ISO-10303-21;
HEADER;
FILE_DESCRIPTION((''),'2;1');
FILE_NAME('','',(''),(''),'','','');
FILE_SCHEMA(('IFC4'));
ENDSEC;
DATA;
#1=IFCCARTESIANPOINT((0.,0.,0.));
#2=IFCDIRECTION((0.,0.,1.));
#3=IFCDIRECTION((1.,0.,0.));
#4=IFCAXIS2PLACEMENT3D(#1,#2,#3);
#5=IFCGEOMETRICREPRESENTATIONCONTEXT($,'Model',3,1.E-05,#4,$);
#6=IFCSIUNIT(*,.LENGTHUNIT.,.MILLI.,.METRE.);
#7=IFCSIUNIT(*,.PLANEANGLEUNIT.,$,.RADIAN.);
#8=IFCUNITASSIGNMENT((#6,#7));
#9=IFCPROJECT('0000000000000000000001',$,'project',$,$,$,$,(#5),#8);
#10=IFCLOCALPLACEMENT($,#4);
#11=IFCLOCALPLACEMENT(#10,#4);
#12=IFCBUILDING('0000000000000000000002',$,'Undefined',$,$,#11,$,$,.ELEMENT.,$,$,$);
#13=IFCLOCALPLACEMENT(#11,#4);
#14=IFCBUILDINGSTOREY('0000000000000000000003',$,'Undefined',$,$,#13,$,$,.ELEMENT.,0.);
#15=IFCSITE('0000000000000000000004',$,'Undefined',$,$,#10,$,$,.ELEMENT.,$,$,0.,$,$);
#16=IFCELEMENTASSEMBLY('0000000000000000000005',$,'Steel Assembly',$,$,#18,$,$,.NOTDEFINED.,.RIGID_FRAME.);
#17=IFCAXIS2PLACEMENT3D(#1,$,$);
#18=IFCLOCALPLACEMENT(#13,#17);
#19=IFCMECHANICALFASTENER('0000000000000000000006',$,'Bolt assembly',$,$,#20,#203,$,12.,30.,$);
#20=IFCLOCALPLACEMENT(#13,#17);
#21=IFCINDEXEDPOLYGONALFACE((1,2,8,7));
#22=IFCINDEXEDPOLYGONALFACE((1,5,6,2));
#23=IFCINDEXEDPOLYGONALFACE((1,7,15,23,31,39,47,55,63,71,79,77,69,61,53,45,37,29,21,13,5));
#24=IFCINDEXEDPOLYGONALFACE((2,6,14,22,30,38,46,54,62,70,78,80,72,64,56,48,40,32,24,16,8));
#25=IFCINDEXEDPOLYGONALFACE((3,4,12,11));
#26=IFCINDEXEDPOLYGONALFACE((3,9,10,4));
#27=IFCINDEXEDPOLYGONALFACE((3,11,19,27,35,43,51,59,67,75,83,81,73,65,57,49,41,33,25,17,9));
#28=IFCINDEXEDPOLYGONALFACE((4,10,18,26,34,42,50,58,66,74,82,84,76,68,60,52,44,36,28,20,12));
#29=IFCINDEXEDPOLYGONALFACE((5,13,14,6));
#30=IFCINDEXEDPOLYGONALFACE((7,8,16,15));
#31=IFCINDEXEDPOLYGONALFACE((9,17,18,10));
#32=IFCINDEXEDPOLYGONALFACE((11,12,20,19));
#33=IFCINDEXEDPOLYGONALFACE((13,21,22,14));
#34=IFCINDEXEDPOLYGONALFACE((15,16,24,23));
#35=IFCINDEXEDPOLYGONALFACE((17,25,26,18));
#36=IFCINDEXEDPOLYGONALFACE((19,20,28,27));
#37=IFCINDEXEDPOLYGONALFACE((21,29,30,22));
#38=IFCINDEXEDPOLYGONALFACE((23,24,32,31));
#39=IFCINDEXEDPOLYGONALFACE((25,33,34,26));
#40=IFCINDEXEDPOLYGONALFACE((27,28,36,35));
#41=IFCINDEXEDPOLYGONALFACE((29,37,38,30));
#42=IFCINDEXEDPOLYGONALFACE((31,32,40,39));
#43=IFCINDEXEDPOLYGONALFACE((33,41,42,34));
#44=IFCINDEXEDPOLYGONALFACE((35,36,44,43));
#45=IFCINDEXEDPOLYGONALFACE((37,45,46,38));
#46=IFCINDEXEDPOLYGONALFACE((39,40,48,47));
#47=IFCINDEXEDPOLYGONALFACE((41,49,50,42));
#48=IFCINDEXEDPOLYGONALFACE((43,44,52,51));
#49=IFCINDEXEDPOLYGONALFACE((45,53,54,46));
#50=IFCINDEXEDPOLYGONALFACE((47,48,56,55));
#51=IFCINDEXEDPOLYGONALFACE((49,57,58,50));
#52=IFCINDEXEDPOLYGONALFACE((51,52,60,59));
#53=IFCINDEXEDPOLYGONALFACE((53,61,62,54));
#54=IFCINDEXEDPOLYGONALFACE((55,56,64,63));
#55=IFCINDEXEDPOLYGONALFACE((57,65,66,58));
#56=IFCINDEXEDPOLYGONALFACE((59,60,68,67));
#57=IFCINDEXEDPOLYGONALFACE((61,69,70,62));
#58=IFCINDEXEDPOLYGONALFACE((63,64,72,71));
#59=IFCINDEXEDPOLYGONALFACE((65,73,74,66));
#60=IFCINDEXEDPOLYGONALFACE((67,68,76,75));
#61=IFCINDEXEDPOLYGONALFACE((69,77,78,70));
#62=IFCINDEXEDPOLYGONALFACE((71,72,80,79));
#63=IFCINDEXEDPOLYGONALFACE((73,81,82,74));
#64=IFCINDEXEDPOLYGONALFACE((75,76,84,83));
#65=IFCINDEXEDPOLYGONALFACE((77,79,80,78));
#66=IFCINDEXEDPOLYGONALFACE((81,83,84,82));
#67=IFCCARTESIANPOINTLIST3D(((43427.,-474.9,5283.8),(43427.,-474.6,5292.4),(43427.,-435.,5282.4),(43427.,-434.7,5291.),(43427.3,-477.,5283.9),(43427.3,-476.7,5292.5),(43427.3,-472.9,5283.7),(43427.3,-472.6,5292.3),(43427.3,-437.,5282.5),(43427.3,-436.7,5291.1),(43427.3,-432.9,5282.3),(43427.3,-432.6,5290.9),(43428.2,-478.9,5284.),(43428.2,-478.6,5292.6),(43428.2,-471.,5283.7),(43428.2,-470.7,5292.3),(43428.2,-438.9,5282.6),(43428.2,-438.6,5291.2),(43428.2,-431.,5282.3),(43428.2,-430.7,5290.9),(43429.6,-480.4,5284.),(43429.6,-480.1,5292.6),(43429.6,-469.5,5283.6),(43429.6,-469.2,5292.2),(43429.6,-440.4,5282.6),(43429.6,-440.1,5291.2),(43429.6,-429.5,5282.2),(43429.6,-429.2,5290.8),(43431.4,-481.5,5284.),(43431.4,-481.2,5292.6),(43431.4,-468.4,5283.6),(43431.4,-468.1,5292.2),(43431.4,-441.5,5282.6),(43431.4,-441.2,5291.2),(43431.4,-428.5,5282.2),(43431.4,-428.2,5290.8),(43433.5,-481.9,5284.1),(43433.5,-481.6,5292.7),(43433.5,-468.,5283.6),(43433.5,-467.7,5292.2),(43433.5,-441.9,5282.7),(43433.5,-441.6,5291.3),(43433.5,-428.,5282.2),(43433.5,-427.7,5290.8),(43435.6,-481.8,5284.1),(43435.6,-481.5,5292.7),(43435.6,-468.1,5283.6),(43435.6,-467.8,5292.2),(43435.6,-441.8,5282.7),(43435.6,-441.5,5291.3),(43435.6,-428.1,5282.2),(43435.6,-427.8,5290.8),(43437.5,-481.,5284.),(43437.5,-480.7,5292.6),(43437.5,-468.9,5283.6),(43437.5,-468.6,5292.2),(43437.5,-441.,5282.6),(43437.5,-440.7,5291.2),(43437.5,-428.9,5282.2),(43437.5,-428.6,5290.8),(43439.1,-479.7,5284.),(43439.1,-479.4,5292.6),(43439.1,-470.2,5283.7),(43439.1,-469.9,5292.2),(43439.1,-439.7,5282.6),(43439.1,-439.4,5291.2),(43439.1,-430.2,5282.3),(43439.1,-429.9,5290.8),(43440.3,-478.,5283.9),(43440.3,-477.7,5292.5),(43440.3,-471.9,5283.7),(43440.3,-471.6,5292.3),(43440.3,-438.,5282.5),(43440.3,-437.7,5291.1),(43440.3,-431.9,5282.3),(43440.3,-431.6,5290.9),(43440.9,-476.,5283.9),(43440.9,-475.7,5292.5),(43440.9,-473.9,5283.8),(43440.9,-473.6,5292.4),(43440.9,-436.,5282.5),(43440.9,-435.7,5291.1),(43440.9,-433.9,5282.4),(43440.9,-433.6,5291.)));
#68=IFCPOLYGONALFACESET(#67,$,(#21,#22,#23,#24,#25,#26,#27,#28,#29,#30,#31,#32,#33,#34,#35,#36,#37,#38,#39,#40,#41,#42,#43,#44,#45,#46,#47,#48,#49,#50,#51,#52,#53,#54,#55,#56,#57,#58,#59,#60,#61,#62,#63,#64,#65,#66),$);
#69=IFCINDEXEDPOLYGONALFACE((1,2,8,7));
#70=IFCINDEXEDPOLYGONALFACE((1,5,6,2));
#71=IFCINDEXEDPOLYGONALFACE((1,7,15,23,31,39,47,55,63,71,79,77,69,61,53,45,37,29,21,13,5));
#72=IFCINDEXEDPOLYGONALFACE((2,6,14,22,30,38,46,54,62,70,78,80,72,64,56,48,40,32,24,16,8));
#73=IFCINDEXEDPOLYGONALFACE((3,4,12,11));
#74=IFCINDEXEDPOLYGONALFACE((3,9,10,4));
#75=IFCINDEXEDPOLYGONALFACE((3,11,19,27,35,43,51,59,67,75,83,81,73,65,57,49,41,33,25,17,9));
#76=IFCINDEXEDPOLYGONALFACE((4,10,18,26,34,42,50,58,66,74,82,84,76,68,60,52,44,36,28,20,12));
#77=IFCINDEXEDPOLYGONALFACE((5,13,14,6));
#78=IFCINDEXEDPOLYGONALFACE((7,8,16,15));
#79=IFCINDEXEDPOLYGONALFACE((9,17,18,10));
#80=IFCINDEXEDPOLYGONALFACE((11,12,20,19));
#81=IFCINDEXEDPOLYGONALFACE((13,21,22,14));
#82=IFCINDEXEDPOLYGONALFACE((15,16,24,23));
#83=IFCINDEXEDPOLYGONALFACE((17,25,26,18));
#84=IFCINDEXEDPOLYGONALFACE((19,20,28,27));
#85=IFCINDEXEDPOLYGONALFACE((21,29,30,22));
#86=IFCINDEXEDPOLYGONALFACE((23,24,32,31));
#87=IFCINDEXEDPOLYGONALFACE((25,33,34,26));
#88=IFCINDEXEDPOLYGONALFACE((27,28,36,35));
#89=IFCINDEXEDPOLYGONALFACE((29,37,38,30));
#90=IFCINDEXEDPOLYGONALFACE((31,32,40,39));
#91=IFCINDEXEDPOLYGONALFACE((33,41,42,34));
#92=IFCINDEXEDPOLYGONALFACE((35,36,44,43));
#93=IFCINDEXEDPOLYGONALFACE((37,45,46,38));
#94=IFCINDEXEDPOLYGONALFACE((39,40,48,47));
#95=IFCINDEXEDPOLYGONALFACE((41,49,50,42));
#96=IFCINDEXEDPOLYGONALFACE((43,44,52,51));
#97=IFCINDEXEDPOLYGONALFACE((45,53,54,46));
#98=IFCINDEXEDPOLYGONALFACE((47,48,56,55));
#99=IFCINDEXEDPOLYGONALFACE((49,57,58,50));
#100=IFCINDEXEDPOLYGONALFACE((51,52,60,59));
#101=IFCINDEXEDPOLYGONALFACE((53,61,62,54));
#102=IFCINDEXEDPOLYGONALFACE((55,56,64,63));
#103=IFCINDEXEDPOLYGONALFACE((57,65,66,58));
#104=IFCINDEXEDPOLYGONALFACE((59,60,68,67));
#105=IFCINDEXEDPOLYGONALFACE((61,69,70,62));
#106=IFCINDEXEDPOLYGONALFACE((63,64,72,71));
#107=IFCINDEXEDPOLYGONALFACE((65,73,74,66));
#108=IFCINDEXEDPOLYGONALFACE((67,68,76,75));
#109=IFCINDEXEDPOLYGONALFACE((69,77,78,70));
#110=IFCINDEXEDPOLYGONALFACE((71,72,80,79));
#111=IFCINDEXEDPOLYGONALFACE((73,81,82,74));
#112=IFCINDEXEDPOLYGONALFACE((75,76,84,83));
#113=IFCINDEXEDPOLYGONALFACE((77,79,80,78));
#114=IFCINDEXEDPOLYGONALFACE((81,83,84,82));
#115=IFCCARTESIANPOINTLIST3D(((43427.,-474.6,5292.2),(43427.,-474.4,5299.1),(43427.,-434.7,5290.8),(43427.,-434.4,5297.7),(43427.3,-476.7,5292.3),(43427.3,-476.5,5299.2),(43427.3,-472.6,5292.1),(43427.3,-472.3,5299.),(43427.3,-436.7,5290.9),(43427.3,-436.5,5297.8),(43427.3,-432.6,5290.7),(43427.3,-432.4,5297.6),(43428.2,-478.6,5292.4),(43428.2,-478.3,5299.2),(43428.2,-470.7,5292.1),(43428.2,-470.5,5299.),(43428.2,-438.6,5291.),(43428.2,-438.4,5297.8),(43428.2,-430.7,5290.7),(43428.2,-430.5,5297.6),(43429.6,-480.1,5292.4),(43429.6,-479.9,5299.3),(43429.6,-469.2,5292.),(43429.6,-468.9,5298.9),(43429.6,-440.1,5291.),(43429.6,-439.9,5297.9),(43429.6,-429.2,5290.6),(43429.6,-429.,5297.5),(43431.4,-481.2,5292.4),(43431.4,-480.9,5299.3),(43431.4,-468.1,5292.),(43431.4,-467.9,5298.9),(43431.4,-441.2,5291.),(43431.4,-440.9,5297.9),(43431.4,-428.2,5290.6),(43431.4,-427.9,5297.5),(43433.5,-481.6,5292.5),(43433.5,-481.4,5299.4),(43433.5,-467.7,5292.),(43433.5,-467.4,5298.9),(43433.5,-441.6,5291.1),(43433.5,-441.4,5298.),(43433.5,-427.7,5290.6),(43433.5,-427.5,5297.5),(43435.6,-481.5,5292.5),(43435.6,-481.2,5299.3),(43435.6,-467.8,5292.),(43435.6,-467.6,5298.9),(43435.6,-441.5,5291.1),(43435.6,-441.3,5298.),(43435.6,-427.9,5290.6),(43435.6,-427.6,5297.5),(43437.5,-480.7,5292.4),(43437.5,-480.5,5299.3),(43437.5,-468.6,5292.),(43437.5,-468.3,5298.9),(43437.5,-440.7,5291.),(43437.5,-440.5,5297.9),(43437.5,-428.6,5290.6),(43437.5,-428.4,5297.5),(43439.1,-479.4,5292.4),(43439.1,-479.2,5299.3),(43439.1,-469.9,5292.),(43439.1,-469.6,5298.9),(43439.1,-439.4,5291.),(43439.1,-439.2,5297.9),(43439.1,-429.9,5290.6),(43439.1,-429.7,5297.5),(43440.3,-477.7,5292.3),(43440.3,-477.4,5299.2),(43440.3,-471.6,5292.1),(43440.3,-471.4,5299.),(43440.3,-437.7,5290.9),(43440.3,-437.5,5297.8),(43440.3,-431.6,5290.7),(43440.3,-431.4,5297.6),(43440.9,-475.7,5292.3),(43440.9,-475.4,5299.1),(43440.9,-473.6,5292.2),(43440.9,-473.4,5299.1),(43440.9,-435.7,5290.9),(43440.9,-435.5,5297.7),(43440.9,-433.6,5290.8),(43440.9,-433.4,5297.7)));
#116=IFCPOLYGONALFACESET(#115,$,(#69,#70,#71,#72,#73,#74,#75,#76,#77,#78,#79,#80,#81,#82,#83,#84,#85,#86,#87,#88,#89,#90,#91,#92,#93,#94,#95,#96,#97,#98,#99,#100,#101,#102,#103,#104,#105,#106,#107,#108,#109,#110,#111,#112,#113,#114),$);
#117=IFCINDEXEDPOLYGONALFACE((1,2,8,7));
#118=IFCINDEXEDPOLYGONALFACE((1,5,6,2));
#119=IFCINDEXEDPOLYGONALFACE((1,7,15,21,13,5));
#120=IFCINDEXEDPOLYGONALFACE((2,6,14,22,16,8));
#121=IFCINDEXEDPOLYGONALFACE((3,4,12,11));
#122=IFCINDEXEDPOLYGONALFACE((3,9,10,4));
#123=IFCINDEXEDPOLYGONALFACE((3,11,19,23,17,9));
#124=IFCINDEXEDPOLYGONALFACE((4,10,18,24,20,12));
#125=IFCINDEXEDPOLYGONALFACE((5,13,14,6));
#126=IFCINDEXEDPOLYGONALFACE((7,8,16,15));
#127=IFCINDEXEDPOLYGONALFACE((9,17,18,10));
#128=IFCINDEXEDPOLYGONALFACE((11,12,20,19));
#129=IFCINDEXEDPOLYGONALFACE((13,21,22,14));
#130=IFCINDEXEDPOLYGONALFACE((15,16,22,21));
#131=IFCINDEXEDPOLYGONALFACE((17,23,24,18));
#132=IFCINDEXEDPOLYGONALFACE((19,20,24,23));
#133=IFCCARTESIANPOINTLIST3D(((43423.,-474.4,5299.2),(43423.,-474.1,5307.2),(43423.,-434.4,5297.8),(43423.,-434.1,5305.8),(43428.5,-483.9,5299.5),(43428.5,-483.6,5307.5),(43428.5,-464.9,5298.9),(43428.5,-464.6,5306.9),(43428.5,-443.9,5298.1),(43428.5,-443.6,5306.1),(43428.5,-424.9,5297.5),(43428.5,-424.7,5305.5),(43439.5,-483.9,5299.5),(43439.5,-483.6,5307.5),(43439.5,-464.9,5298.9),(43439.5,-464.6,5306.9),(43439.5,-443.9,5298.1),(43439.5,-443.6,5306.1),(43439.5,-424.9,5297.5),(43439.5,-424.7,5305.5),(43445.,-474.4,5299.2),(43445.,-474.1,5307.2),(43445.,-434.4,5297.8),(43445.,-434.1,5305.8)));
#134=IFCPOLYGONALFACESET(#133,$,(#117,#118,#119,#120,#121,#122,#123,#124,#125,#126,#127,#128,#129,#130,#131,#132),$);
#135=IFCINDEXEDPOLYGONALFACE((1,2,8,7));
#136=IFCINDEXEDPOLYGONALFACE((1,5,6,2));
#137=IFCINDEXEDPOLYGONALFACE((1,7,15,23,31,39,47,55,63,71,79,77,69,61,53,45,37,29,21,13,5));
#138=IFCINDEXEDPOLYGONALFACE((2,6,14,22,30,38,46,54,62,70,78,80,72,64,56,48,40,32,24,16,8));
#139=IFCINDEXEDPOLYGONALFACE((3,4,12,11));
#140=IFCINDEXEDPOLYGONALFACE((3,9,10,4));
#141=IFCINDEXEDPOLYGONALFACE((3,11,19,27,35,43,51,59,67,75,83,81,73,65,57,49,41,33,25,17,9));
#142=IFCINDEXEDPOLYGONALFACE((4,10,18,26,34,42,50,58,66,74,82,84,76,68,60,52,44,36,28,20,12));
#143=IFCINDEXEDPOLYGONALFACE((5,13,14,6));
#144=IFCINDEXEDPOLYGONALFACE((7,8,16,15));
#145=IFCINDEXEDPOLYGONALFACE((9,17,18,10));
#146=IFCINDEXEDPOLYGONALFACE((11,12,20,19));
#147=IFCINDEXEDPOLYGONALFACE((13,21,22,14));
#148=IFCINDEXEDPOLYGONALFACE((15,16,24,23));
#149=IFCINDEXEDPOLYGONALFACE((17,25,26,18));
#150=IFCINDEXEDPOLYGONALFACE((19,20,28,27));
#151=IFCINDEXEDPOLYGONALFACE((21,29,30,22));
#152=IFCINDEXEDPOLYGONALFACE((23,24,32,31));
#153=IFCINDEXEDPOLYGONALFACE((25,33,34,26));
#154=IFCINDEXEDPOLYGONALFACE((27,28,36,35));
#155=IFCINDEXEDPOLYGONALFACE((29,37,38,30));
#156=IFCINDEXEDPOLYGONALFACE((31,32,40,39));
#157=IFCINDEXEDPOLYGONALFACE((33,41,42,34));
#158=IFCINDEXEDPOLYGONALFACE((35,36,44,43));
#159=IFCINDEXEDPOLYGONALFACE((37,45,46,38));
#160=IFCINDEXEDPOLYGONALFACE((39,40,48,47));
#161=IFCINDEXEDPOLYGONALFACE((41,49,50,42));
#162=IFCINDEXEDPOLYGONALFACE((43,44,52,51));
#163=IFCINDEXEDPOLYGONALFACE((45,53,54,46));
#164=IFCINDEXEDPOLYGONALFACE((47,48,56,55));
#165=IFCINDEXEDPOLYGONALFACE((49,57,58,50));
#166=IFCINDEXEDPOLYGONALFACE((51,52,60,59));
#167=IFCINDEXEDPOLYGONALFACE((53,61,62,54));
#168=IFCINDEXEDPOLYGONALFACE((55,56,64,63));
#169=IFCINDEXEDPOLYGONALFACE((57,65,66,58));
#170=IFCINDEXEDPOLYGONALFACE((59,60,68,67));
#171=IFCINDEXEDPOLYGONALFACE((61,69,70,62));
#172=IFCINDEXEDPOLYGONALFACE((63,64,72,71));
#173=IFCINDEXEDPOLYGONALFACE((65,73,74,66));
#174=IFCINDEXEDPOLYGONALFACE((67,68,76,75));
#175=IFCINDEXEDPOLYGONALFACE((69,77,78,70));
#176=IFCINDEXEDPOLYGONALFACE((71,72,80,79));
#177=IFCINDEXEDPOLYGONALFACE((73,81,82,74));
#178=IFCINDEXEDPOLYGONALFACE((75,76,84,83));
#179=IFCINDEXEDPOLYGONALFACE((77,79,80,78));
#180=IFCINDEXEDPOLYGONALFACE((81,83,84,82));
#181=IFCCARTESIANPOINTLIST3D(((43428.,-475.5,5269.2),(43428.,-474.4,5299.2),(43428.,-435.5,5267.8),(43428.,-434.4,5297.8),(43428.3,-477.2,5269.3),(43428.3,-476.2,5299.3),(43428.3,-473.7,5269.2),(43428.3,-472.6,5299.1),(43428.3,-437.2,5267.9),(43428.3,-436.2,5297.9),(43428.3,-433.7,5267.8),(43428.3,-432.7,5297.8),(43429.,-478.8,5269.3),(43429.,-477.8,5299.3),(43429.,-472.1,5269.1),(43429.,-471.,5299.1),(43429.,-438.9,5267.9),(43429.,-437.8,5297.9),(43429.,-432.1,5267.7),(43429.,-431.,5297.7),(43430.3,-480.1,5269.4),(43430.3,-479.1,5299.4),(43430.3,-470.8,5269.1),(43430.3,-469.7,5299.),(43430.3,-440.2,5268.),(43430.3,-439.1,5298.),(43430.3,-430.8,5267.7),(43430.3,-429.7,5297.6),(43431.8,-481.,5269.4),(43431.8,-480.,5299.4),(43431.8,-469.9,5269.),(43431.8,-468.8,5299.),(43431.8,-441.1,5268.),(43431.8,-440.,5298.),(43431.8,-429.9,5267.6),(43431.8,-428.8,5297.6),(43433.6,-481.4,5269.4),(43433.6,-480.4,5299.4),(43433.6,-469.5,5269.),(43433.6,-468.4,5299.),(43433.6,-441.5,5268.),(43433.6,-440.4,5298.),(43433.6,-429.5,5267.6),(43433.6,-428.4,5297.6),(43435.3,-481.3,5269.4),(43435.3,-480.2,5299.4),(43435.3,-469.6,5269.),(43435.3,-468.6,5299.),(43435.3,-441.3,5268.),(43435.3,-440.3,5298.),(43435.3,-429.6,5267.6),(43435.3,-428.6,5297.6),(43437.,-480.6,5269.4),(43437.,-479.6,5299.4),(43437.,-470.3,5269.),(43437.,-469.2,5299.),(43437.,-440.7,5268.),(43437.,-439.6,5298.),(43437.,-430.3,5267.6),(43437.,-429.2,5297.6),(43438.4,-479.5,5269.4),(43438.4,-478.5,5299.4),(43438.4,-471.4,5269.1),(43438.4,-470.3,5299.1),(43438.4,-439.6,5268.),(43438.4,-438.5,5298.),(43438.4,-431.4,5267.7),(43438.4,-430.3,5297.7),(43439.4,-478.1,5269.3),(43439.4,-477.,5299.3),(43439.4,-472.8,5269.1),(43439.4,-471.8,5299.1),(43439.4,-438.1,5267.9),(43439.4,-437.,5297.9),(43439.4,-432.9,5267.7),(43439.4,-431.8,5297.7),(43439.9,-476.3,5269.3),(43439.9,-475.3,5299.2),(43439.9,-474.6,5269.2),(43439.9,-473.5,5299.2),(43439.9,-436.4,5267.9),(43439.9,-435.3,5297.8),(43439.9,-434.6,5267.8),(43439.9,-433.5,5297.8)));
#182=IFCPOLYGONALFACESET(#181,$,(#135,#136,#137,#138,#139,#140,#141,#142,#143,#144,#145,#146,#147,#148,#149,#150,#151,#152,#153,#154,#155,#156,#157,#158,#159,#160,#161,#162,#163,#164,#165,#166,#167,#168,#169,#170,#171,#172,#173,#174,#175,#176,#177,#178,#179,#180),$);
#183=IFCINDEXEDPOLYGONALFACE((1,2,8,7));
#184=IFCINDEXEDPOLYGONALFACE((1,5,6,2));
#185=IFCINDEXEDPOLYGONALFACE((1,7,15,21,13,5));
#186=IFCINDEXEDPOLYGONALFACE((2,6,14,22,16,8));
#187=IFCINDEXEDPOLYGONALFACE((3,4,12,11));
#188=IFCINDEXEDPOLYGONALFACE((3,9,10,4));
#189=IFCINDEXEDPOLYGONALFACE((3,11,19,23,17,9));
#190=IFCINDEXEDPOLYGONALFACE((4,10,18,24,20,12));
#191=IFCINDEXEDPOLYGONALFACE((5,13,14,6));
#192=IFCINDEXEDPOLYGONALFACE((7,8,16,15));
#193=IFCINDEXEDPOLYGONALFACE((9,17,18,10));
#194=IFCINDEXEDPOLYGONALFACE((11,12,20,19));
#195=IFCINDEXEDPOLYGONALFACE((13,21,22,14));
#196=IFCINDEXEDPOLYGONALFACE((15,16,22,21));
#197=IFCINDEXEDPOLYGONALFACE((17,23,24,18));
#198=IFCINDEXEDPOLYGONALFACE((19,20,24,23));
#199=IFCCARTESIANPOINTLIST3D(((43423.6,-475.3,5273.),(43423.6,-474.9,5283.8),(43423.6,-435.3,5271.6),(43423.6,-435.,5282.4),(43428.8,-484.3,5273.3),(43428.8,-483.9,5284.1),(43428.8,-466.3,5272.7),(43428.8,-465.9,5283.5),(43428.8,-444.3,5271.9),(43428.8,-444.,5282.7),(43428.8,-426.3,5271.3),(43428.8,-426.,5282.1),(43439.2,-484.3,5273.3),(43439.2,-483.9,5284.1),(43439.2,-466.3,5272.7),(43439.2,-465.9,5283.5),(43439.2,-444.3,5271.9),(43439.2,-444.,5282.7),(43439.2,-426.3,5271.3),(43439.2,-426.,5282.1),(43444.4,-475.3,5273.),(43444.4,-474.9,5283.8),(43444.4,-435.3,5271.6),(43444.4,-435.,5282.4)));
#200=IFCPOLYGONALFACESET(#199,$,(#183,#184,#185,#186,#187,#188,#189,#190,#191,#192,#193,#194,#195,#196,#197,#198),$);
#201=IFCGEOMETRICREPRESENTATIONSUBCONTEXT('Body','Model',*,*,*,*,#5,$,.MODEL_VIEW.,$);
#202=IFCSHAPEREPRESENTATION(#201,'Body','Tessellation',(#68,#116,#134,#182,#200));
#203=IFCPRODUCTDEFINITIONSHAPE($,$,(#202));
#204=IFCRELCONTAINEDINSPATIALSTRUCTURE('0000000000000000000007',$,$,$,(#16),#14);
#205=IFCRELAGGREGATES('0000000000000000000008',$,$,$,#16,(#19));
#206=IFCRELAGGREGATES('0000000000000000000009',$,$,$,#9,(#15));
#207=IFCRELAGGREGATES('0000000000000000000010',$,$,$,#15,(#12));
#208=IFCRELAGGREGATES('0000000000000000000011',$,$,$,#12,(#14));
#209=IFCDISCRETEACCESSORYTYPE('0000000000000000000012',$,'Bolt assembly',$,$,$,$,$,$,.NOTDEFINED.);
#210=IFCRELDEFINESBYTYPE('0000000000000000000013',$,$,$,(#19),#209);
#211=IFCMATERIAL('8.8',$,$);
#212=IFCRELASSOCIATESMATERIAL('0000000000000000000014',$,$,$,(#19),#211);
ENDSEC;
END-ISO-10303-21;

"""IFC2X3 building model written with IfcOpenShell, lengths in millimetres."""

from ifc_helpers import new_model, si_unit, frame, origin_with_axes, origin_2d_with_axis, place, context, subcontext, project, spatial, polyline, circle, outline, extrude, source, transform, mapped, material, type_object, element, aggregate, save


model = new_model("IFC2X3")

# Units and contexts
model_context = context("Model", 3, precision=1e-05, world=origin_with_axes())
body_context = subcontext(model_context, "Body", "Model", "MODEL_VIEW")
ifc_project = project(units=[si_unit("LENGTHUNIT", "METRE", prefix="MILLI"), si_unit("PLANEANGLEUNIT", "RADIAN")], contexts=[model_context])

# Site, building, storey
site_placement = place(None, origin_with_axes())
site = spatial("IfcSite", under=ifc_project, at=site_placement, Name="Undefined", CompositionType="ELEMENT", RefElevation=0.0)
building_placement = place(site_placement, origin_with_axes())
building = spatial("IfcBuilding", under=site, at=building_placement, Name="Undefined", CompositionType="ELEMENT")
storey_placement = place(building_placement, origin_with_axes())
storey = spatial("IfcBuildingStorey", under=building, at=storey_placement, Name="Undefined", CompositionType="ELEMENT", Elevation=0.0)

# Shared definitions
discrete_accessory_type_1 = type_object("IfcDiscreteAccessoryType", Name="Bolt assembly")

# Element assembly, mechanical fastener
assembly_1_placement = place(storey_placement, origin_with_axes())
assembly_1 = element("IfcElementAssembly", 1, at=assembly_1_placement, inside=storey, Name="Steel Assembly", AssemblyPlace="NOTDEFINED", PredefinedType="RIGID_FRAME")
ifc_material_1 = material(Name="8.8")
shared_shape_1 = source(origin_with_axes(), body_context, "Body", "SweptSolid", [
    extrude(circle(Radius=7.0, at=origin_2d_with_axis()), frame((0.0, -0.1, 0.0), z_axis=(0.0, 1.0, 0.0), x_axis=(1.0, 0.0, 0.0)), (0.0, 0.0, 1.0), 8.6),
    extrude(circle(Radius=7.0, at=origin_2d_with_axis()), frame((0.0, -6.8, 0.0), z_axis=(0.0, 1.0, 0.0), x_axis=(1.0, 0.0, 0.0)), (0.0, 0.0, 1.0), 6.9),
    extrude(outline(polyline([(11.0, 0.0), (5.5, 9.5), (-5.5, 9.5), (-11.0, 0.0), (-5.5, -9.5), (5.5, -9.5), (11.0, 0.0)])), frame((0.0, -14.9, 0.0), z_axis=(0.0, 1.0, 0.0), x_axis=(1.0, 0.0, 0.0)), (0.0, 0.0, 1.0), 8.0),
    extrude(circle(Radius=6.0, at=origin_2d_with_axis()), frame((0.0, -6.9, 0.0), z_axis=(0.0, 1.0, 0.0), x_axis=(1.0, 0.0, 0.0)), (0.0, 0.0, 1.0), 30.0),
    extrude(outline(polyline([(10.4, 0.0), (5.2, 9.0), (-5.2, 9.0), (-10.4, 0.0), (-5.2, -9.0), (5.2, -9.0), (10.4, 0.0)])), frame((0.0, 8.5, 0.0), z_axis=(0.0, 1.0, 0.0), x_axis=(1.0, 0.0, 0.0)), (0.0, 0.0, 1.0), 10.8),
])
mechanical_fastener_1_placement = place(assembly_1_placement, frame((43434.0, -454.7, 5291.6), z_axis=(-0.000003, -0.999388, 0.034975), x_axis=(-1.0, 0.000003, 0.0)))
mechanical_fastener_1 = element("IfcMechanicalFastener", 2, at=mechanical_fastener_1_placement, type_object=discrete_accessory_type_1, material=ifc_material_1, Name="Bolt assembly", NominalDiameter=12.0, NominalLength=30.0, context=body_context, shape_type="MappedRepresentation", body=[
    mapped(shared_shape_1, transform((0.0, 0.0, -20.0))),
    mapped(shared_shape_1, transform((0.0, 0.0, 20.0))),
])
aggregate(assembly_1, [mechanical_fastener_1])

save(model, "model.ifc")
